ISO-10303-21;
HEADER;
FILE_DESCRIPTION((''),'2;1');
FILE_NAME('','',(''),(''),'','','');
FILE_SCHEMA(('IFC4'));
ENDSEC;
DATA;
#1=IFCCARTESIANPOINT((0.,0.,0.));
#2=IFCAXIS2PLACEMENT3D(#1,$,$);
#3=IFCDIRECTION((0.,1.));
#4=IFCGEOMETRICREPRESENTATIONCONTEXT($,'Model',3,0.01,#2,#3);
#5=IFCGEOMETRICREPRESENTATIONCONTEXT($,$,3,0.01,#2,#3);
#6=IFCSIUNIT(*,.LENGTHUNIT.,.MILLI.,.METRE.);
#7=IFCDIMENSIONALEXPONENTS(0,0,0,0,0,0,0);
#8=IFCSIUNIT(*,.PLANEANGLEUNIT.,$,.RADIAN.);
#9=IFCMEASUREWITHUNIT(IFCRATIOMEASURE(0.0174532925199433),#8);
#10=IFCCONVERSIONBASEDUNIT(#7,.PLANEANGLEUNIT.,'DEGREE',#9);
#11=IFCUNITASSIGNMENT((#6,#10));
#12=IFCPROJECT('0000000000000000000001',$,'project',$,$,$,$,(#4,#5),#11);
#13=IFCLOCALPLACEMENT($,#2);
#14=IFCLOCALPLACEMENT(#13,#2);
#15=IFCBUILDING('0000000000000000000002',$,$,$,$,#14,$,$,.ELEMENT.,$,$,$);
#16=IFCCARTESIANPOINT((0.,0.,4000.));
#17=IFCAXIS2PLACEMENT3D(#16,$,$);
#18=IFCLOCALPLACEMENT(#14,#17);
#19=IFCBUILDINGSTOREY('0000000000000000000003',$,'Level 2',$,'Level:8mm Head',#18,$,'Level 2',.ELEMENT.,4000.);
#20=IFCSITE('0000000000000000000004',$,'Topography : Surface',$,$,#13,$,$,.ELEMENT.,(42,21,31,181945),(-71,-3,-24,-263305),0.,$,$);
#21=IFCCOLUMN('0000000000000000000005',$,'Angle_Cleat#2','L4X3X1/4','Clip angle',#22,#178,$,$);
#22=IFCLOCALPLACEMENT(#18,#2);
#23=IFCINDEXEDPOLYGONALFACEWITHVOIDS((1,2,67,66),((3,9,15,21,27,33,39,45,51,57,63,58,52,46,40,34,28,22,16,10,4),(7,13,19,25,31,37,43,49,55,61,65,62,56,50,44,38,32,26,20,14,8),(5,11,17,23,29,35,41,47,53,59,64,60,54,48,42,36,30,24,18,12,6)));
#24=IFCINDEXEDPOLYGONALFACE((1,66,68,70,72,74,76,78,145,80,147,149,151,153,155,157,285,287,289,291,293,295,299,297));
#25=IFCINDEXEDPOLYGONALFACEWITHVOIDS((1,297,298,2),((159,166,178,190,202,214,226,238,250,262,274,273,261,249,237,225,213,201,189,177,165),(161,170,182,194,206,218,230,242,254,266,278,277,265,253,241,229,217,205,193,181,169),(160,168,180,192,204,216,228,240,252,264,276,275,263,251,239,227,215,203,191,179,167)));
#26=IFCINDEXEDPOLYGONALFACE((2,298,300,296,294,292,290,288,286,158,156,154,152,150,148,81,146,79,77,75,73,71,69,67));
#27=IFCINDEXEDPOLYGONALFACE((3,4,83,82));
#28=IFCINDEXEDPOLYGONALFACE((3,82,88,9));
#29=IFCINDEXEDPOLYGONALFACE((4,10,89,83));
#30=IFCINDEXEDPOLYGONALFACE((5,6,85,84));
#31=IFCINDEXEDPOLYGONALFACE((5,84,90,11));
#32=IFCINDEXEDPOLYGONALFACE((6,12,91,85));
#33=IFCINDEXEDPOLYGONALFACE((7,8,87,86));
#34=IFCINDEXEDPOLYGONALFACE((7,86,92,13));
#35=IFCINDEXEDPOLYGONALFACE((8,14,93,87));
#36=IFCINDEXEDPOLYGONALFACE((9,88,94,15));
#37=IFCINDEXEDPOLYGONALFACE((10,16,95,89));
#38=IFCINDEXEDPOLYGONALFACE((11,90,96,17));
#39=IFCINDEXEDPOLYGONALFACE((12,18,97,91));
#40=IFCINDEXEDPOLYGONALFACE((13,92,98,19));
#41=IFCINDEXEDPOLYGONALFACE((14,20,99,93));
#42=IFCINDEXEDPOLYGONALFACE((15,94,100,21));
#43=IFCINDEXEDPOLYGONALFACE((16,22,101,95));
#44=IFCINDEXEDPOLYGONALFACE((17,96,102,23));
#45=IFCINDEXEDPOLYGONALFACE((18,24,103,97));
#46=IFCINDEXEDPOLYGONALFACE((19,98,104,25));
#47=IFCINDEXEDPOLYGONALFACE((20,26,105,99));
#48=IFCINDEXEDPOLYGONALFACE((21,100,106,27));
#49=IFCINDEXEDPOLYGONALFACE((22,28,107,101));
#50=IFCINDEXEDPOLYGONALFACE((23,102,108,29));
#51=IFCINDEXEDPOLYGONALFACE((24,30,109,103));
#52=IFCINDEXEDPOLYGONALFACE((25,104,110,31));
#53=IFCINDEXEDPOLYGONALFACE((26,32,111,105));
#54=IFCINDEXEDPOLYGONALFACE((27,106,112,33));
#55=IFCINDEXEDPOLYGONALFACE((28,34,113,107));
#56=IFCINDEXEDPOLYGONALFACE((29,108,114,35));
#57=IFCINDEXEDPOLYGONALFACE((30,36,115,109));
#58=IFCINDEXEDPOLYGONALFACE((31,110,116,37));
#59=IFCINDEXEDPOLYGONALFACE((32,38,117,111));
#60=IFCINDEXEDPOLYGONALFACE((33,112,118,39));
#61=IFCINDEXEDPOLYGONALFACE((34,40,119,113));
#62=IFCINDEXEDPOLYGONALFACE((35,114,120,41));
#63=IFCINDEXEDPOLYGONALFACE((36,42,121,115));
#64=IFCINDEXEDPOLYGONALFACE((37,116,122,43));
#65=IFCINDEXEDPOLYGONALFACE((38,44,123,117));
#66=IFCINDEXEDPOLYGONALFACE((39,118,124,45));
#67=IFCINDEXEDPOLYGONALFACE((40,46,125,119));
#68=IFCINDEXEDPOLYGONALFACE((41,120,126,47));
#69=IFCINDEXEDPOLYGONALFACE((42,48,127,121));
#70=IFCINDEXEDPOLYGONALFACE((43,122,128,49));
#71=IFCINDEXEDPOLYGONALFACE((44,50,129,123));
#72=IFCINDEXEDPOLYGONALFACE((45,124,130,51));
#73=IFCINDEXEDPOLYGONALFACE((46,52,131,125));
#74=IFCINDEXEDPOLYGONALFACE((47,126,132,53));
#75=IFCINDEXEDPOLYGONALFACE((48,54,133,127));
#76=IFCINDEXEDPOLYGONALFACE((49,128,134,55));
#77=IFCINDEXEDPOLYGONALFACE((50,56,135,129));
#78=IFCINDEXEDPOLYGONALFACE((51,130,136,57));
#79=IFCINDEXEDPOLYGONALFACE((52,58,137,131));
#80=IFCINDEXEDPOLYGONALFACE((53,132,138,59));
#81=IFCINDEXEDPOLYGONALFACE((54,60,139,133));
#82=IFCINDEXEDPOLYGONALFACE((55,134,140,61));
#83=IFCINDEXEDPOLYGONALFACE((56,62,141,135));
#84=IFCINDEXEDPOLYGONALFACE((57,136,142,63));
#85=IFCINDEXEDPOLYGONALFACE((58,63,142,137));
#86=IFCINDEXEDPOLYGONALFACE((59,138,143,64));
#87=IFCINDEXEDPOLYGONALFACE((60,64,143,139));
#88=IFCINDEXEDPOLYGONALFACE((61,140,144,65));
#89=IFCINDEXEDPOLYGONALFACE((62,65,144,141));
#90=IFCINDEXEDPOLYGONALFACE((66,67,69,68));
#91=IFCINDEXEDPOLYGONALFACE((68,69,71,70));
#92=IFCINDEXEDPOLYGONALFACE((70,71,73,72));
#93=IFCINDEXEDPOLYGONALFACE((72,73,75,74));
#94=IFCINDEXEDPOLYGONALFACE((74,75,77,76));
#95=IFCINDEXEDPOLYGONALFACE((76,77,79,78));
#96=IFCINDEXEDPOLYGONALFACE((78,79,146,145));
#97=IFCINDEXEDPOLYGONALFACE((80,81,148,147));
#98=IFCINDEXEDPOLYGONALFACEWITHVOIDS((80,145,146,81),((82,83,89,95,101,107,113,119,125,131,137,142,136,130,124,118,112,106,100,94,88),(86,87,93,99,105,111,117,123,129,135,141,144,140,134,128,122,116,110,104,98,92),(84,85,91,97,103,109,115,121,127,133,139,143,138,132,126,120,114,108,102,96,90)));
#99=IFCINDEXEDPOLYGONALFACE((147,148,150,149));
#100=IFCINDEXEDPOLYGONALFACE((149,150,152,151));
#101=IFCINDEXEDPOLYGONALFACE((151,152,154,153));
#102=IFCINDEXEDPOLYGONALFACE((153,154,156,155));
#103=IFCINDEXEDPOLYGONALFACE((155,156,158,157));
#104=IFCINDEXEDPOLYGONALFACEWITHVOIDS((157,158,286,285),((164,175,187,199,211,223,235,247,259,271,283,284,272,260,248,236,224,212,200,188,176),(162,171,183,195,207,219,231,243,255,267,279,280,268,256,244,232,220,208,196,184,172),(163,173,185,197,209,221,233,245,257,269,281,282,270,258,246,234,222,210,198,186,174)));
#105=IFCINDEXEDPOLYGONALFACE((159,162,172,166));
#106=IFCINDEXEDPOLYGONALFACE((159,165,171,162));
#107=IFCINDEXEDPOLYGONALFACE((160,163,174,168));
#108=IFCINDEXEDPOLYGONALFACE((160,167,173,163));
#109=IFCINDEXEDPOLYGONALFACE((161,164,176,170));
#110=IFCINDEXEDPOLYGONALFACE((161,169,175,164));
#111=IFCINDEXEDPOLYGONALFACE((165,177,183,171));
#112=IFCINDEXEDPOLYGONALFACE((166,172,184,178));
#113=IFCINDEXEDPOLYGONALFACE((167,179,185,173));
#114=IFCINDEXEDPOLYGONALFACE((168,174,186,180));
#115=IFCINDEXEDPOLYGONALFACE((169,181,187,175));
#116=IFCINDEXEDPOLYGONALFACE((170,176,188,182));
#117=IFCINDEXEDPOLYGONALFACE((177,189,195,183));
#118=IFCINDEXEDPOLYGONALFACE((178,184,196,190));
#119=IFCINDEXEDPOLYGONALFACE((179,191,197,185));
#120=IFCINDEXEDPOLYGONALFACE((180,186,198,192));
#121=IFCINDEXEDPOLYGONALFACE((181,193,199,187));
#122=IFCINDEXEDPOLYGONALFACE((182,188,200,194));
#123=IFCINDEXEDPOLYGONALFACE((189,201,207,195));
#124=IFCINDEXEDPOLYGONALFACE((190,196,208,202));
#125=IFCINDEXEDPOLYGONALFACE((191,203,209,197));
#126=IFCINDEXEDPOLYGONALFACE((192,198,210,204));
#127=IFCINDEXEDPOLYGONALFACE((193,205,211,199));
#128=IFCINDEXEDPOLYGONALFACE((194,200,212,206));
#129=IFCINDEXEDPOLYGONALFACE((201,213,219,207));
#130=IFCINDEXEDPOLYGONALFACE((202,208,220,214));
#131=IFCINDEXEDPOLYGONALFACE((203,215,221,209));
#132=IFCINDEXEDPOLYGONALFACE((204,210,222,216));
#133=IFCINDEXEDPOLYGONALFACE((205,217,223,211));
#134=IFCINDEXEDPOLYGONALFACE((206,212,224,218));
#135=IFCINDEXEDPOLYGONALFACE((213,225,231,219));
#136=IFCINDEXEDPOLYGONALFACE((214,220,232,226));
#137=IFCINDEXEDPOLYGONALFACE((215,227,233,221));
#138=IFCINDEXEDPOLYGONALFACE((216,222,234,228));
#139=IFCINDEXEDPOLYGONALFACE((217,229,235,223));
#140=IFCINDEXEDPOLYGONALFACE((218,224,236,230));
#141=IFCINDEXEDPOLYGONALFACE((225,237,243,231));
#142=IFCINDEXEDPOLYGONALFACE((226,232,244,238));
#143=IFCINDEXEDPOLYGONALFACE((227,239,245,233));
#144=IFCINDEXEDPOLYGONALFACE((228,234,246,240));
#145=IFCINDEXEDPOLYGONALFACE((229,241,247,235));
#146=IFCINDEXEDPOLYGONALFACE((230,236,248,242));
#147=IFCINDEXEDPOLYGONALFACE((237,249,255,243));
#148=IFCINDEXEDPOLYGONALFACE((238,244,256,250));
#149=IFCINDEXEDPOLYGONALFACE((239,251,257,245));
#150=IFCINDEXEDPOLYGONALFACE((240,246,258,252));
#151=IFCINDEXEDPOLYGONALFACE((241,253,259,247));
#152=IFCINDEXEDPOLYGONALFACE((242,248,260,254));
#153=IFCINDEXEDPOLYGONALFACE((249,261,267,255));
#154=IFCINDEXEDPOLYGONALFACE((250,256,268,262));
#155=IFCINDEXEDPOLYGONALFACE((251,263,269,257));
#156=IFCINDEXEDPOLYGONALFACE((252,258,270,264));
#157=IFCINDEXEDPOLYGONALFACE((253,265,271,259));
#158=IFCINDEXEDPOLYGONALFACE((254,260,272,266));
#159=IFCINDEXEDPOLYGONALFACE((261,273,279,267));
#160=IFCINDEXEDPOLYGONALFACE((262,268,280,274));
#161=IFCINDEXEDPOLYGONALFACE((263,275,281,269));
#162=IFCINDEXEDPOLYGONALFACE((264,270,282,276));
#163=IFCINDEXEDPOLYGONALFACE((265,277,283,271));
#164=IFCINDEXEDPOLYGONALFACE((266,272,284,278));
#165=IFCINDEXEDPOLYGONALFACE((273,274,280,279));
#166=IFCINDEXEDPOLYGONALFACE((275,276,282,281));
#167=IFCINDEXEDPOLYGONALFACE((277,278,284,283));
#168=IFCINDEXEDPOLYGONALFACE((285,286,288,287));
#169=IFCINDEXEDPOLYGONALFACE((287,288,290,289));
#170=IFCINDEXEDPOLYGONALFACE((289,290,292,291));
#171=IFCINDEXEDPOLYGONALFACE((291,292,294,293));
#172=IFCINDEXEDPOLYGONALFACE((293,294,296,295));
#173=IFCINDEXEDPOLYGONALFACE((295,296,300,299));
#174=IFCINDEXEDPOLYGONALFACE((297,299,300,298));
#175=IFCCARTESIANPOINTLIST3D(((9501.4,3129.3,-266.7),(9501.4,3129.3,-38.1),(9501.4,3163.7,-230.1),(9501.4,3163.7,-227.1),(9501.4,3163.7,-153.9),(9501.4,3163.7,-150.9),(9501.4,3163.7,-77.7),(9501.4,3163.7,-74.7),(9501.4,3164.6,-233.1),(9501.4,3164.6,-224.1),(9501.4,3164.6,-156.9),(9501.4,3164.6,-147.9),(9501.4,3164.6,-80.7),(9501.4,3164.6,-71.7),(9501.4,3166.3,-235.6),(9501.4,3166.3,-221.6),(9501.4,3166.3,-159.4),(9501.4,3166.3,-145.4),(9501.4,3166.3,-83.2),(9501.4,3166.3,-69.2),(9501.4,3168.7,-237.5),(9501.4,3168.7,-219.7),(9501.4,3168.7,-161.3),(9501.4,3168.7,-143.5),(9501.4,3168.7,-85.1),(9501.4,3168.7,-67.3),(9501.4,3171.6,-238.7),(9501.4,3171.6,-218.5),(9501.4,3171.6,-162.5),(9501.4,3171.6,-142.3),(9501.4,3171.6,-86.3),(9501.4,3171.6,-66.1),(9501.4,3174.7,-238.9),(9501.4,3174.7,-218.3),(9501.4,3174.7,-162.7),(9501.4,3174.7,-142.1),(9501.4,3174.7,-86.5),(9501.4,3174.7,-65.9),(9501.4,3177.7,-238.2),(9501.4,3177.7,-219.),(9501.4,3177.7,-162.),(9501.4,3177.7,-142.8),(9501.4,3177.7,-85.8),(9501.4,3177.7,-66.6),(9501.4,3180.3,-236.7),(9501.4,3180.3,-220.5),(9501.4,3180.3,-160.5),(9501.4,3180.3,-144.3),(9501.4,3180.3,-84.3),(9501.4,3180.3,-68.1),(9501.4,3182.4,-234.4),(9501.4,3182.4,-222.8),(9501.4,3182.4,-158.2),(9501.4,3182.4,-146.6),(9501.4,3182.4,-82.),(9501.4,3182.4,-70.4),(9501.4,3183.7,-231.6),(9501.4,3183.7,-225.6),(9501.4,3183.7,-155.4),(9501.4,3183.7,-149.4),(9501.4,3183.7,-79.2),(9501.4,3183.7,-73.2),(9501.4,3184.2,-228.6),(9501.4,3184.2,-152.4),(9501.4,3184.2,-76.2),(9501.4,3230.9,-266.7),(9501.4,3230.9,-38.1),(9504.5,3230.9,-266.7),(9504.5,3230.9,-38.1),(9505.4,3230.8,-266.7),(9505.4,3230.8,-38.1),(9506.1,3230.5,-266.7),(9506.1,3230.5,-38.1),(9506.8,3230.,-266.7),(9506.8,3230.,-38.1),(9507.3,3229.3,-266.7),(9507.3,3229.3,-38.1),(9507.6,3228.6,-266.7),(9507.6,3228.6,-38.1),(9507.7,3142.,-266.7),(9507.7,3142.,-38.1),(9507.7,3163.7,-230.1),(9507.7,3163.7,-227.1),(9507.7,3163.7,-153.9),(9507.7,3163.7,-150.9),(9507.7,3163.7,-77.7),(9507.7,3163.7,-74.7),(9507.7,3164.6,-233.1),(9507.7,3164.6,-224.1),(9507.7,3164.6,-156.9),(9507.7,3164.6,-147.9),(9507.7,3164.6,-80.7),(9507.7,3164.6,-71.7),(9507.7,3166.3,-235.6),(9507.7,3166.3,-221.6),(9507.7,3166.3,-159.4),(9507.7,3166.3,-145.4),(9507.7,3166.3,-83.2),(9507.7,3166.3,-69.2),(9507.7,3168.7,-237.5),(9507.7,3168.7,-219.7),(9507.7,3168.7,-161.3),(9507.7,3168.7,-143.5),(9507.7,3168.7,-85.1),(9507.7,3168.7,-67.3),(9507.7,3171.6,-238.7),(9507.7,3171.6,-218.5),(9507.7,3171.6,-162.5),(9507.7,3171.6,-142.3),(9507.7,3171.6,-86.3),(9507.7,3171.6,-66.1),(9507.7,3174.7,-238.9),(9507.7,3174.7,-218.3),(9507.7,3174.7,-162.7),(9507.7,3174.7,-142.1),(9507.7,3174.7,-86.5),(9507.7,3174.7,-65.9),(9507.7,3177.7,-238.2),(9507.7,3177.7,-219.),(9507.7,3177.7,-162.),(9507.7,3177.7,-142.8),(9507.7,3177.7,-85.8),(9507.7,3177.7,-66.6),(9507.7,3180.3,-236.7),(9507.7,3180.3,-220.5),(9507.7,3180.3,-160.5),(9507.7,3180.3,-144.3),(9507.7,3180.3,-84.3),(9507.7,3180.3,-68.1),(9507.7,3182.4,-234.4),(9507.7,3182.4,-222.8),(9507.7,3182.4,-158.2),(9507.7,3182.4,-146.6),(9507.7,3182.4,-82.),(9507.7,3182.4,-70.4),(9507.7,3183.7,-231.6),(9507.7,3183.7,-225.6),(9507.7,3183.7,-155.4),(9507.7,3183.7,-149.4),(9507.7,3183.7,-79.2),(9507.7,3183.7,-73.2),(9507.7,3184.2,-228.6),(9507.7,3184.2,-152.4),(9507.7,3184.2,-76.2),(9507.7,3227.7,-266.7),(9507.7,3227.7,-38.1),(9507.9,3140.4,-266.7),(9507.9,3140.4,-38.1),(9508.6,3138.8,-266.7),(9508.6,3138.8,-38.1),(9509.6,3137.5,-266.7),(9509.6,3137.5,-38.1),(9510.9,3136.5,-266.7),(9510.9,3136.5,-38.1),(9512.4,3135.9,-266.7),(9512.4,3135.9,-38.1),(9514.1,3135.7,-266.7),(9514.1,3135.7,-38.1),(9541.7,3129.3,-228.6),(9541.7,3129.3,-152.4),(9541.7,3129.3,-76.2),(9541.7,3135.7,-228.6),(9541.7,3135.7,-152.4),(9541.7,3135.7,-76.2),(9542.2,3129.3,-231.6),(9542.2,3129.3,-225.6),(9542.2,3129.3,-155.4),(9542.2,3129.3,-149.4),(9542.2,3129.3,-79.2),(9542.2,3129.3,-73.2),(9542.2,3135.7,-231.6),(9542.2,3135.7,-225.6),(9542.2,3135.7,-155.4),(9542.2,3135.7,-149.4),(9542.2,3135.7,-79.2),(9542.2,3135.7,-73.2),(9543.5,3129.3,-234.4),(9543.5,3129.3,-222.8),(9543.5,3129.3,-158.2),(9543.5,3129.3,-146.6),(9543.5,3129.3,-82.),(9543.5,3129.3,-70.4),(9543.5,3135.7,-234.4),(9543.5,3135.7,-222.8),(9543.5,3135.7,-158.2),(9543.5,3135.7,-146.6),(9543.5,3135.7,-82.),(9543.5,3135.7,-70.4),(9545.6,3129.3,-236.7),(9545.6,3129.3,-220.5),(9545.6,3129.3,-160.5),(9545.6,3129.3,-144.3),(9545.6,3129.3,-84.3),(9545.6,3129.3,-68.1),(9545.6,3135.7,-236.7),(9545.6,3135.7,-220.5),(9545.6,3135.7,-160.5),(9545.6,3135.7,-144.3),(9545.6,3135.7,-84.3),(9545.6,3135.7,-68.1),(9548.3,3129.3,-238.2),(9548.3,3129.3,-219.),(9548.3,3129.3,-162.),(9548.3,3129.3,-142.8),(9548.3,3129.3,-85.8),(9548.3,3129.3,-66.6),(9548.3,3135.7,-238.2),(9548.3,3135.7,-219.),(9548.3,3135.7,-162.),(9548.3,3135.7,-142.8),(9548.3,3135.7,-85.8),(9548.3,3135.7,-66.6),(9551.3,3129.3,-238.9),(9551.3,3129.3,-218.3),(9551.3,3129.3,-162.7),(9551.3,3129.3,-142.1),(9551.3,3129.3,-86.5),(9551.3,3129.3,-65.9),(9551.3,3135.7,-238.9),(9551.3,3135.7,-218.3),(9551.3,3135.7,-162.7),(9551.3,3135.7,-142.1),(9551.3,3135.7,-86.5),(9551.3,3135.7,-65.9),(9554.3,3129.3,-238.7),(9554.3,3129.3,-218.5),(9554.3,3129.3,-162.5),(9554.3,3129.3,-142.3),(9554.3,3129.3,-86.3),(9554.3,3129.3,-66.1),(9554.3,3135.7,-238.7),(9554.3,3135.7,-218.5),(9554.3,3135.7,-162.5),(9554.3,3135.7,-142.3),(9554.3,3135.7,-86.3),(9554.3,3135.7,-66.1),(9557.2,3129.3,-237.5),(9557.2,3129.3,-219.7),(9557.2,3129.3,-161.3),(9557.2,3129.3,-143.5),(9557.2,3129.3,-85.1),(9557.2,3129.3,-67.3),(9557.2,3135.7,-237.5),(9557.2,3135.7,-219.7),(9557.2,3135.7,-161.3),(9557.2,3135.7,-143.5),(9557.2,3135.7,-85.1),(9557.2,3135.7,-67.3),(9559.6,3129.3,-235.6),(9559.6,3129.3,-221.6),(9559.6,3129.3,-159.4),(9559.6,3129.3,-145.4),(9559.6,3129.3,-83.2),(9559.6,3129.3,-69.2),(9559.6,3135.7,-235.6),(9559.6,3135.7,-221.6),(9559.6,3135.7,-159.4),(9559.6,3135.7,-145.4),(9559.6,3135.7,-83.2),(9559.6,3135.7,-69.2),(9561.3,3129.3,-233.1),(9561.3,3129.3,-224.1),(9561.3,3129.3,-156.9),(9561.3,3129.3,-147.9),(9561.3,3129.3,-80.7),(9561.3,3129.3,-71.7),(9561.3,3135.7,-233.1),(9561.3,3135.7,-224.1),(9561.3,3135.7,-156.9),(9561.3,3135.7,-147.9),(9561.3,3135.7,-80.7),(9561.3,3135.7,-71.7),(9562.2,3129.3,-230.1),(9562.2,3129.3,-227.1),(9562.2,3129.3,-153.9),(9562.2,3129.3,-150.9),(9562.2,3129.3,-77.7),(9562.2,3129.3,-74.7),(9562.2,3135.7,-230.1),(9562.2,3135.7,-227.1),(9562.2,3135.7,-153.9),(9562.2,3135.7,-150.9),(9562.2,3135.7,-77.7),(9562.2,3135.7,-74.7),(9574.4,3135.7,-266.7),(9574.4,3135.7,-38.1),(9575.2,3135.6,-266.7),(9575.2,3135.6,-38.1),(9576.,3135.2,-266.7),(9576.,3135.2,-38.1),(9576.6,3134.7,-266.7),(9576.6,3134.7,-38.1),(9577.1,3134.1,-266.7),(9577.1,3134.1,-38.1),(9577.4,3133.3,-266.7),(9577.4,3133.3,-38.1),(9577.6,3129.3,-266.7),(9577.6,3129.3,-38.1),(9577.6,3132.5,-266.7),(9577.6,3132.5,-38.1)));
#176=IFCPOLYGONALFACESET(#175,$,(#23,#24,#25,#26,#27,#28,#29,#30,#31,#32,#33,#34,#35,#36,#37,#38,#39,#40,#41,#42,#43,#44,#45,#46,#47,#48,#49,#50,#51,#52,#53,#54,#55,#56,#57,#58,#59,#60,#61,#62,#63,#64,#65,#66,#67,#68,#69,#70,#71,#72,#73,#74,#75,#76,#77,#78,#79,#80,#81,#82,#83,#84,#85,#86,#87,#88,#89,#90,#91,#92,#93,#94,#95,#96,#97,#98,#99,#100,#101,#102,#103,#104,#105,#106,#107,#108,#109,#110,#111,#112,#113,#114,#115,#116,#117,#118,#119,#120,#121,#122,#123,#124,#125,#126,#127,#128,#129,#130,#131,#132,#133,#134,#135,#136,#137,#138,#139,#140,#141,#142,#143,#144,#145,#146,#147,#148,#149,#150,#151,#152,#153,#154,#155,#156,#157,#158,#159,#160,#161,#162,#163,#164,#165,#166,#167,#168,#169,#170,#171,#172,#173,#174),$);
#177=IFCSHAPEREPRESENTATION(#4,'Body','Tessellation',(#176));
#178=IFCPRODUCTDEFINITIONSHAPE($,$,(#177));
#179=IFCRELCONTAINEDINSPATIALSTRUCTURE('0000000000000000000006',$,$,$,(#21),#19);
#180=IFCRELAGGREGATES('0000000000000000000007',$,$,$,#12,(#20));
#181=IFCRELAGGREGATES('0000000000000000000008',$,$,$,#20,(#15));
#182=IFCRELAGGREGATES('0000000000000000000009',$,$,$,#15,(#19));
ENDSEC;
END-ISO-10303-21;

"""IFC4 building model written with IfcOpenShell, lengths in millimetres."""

from ifc_helpers import new_model, entity, si_unit, converted_unit, direction, frame, frame_2d, origin, origin_2d_with_axis, place, context, project, spatial, circle, l_section, extrude, element, save


model = new_model("IFC4")

# Units and contexts
model_context = context("Model", 3, precision=0.01, world=origin(), true_north=direction((0.0, 1.0)))
context_of_model = context(None, 3, precision=0.01, world=origin(), true_north=direction((0.0, 1.0)))
ifc_project = project(units=[si_unit("LENGTHUNIT", "METRE", prefix="MILLI"), converted_unit("PLANEANGLEUNIT", "DEGREE", entity("IfcRatioMeasure", 0.0174532925199433), si_unit("PLANEANGLEUNIT", "RADIAN"), dimensions=[0, 0, 0, 0, 0, 0, 0])], contexts=[model_context, context_of_model])

# Site, building, storey
site_placement = place(None, origin())
site = spatial("IfcSite", under=ifc_project, at=site_placement, Name="Topography : Surface", CompositionType="ELEMENT", RefLatitude=(42, 21, 31, 181945), RefLongitude=(-71, -3, -24, -263305), RefElevation=0.0)
building_placement = place(site_placement, origin())
building = spatial("IfcBuilding", under=site, at=building_placement, CompositionType="ELEMENT")
storey_placement = place(building_placement, frame((0.0, 0.0, 4000.0)))
storey = spatial("IfcBuildingStorey", under=building, at=storey_placement, Name="Level 2", ObjectType="Level:8mm Head", LongName="Level 2", CompositionType="ELEMENT", Elevation=4000.0)

# Column, openings
column_1_placement = place(storey_placement, frame((9519.6, 3160.4, -38.1)))
column_1 = element("IfcColumn", 1, at=column_1_placement, inside=storey, Name="Angle_Cleat#2", Description="L4X3X1/4", ObjectType="Clip angle", context=model_context, shape_type="SweptSolid", body=[
    extrude(l_section(Depth=101.6, Width=76.2, Thickness=6.3, FilletRadius=6.3, EdgeRadius=3.2, at=frame_2d((19.8, 19.7))), origin(), (0.0, 0.0, -1.0), 228.6),
])
opening_1_placement = place(column_1_placement, frame((32.4, -31.5, -114.3), z_axis=(0.0, 1.0, 0.0), x_axis=(-1.0, 0.0, 0.0)))
element("IfcOpeningElement", 2, at=opening_1_placement, cuts=column_1, ObjectType="Opening", context=model_context, shape_type="SweptSolid", body=[
    extrude(circle(Radius=10.3, at=origin_2d_with_axis()), origin(), (0.0, 0.0, 1.0), 7.3),
])
opening_2_placement = place(column_1_placement, frame((32.4, -31.5, -114.3), z_axis=(0.0, 1.0, 0.0), x_axis=(-1.0, 0.0, 0.0)))
element("IfcOpeningElement", 3, at=opening_2_placement, cuts=column_1, ObjectType="Opening", context=model_context, shape_type="SweptSolid", body=[
    extrude(circle(Radius=10.3, at=frame_2d((0.0, 76.2), x_axis=(1.0, 0.0))), origin(), (0.0, 0.0, 1.0), 7.3),
])
opening_3_placement = place(column_1_placement, frame((32.4, -31.5, -114.3), z_axis=(0.0, 1.0, 0.0), x_axis=(-1.0, 0.0, 0.0)))
element("IfcOpeningElement", 4, at=opening_3_placement, cuts=column_1, ObjectType="Opening", context=model_context, shape_type="SweptSolid", body=[
    extrude(circle(Radius=10.3, at=frame_2d((0.0, -76.2), x_axis=(1.0, 0.0))), origin(), (0.0, 0.0, 1.0), 7.3),
])
opening_4_placement = place(column_1_placement, frame((-11.6, 13.5, -114.3), z_axis=(-1.0, 0.0, 0.0), x_axis=(0.0, 1.0, 0.0)))
element("IfcOpeningElement", 5, at=opening_4_placement, cuts=column_1, ObjectType="Opening", context=model_context, shape_type="SweptSolid", body=[
    extrude(circle(Radius=10.3, at=origin_2d_with_axis()), origin(), (0.0, 0.0, 1.0), 7.3),
])
opening_5_placement = place(column_1_placement, frame((-11.6, 13.5, -114.3), z_axis=(-1.0, 0.0, 0.0), x_axis=(0.0, 1.0, 0.0)))
element("IfcOpeningElement", 6, at=opening_5_placement, cuts=column_1, ObjectType="Opening", context=model_context, shape_type="SweptSolid", body=[
    extrude(circle(Radius=10.3, at=frame_2d((0.0, 76.2), x_axis=(1.0, 0.0))), origin(), (0.0, 0.0, 1.0), 7.3),
])
opening_6_placement = place(column_1_placement, frame((-11.6, 13.5, -114.3), z_axis=(-1.0, 0.0, 0.0), x_axis=(0.0, 1.0, 0.0)))
element("IfcOpeningElement", 7, at=opening_6_placement, cuts=column_1, ObjectType="Opening", context=model_context, shape_type="SweptSolid", body=[
    extrude(circle(Radius=10.3, at=frame_2d((0.0, -76.2), x_axis=(1.0, 0.0))), origin(), (0.0, 0.0, 1.0), 7.3),
])

save(model, "model.ifc")
